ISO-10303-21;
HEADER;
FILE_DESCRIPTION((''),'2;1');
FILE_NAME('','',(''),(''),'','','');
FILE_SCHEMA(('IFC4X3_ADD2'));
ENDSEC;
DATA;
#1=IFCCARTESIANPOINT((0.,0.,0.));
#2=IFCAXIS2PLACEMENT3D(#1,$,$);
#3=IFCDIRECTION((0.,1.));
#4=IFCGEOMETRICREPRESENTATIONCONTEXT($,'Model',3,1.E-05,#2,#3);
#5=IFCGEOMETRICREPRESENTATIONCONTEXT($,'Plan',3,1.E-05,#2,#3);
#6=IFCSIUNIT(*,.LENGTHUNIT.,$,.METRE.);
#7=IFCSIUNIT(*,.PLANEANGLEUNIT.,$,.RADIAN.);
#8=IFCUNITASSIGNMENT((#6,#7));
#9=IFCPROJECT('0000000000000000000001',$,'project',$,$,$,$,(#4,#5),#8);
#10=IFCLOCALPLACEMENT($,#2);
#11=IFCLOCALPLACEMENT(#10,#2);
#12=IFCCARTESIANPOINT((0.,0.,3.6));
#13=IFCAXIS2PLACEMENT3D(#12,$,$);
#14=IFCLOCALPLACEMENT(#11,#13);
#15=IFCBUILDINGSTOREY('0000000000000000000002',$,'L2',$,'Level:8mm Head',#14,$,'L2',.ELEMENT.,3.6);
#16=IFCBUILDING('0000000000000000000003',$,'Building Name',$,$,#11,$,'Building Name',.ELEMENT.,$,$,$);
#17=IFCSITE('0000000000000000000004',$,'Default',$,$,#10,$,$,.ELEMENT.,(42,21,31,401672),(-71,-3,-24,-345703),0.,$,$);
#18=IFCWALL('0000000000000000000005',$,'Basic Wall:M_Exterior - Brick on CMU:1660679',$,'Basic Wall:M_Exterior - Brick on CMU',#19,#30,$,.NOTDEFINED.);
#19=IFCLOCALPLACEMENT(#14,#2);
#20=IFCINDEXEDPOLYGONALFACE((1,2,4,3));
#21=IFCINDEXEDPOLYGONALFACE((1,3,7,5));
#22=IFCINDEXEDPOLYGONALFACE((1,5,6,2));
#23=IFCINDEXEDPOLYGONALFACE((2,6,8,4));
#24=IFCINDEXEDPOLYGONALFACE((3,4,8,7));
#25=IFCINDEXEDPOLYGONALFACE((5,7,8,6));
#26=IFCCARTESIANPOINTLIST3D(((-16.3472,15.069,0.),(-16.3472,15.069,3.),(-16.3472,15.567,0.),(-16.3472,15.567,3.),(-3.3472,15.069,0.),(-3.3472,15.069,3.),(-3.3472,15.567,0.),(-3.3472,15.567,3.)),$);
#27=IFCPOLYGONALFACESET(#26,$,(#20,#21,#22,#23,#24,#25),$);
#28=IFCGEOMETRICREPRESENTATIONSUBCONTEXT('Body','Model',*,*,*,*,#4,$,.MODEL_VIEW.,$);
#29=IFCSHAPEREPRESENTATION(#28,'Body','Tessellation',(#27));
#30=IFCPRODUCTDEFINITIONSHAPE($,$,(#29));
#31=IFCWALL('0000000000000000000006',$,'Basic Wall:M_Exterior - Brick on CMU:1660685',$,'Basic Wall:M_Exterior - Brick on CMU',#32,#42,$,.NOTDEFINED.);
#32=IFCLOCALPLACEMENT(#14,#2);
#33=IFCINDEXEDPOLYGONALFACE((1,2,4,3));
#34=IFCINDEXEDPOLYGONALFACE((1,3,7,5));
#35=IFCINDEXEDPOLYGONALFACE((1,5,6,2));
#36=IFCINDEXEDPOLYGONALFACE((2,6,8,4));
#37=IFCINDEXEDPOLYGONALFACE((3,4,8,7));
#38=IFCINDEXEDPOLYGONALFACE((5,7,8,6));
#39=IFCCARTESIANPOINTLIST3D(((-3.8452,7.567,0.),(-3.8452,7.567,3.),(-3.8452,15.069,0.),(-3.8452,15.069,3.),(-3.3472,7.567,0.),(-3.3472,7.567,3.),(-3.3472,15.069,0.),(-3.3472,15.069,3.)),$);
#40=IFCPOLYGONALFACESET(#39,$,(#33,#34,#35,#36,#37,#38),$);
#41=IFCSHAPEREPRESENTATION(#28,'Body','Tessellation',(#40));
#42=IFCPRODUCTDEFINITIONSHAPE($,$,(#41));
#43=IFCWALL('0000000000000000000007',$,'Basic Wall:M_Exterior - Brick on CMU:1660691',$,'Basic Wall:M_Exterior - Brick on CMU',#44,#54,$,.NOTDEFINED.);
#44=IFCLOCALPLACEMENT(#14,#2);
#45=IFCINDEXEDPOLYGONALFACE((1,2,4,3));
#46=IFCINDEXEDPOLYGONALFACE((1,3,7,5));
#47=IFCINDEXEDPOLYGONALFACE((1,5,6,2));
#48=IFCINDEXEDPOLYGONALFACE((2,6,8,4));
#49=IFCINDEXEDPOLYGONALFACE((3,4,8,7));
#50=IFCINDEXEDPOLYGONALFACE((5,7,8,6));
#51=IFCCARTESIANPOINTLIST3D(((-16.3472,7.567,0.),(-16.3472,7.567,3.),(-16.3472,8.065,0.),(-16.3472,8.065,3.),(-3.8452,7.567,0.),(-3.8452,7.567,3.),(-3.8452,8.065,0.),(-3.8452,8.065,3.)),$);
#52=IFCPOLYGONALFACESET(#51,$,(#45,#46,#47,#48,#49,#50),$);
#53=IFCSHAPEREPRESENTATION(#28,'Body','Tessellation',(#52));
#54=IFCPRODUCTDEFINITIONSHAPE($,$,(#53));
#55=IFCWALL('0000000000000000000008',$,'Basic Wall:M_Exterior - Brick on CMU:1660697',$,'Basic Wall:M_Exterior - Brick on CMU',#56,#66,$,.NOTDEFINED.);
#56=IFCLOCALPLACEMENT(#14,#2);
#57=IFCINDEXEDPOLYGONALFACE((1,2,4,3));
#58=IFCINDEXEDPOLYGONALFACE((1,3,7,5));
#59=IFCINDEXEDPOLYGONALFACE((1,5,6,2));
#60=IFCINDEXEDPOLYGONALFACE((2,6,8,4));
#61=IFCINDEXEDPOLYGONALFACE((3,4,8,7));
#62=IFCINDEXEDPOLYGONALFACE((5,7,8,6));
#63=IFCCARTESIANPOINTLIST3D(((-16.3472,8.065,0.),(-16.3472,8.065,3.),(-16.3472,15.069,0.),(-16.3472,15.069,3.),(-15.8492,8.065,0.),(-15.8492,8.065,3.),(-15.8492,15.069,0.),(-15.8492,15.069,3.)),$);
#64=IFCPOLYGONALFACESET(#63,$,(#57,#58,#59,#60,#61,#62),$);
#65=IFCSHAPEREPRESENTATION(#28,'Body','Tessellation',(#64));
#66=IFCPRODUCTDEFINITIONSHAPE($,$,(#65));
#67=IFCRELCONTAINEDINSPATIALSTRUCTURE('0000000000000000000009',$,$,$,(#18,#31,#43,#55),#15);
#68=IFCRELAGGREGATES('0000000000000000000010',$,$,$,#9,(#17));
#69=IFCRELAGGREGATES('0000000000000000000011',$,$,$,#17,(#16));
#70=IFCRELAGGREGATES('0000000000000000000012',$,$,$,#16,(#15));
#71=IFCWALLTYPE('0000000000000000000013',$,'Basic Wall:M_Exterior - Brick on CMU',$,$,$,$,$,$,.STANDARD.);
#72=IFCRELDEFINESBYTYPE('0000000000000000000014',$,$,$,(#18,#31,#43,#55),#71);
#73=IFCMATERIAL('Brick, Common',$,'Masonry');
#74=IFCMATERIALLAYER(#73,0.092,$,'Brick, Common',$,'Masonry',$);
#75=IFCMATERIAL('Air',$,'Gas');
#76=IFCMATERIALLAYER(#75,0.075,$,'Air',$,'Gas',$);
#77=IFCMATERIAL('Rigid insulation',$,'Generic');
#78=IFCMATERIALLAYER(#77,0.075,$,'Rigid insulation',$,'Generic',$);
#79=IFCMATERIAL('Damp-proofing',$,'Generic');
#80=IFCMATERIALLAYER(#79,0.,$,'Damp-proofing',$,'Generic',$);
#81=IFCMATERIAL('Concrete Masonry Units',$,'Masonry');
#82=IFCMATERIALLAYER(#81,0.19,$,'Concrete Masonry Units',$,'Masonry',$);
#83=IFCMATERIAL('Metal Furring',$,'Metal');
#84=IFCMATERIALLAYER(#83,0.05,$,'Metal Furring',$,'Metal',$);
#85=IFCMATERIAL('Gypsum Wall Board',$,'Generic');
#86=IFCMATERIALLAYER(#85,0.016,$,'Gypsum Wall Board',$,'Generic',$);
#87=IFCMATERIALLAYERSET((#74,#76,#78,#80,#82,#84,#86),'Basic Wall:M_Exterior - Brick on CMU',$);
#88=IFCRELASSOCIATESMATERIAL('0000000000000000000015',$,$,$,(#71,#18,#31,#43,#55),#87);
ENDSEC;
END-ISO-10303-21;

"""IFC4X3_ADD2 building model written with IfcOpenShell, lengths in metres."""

from ifc_helpers import new_model, si_unit, direction, frame, frame_2d, origin, place, context, subcontext, project, spatial, rectangle, extrude, material, layer, layer_set, type_object, element, save


model = new_model("IFC4X3_ADD2")

# Units and contexts
model_context = context("Model", 3, precision=1e-05, world=origin(), true_north=direction((0.0, 1.0)))
plan_context = context("Plan", 3, precision=1e-05, world=origin(), true_north=direction((0.0, 1.0)))
body_context = subcontext(model_context, "Body", "Model", "MODEL_VIEW")
ifc_project = project(units=[si_unit("LENGTHUNIT", "METRE"), si_unit("PLANEANGLEUNIT", "RADIAN")], contexts=[model_context, plan_context])

# Site, building, storey
site_placement = place(None, origin())
site = spatial("IfcSite", under=ifc_project, at=site_placement, Name="Default", CompositionType="ELEMENT", RefLatitude=(42, 21, 31, 401672), RefLongitude=(-71, -3, -24, -345703), RefElevation=0.0)
building_placement = place(site_placement, origin())
building = spatial("IfcBuilding", under=site, at=building_placement, Name="Building Name", LongName="Building Name", CompositionType="ELEMENT")
storey_placement = place(building_placement, frame((0.0, 0.0, 3.6)))
storey = spatial("IfcBuildingStorey", under=building, at=storey_placement, Name="L2", ObjectType="Level:8mm Head", LongName="L2", CompositionType="ELEMENT", Elevation=3.6)

# Walls
ifc_material_1 = material(Name="Brick, Common", Category="Masonry")
ifc_layer_1 = layer(ifc_material_1, 0.092, Name="Brick, Common", Category="Masonry")
ifc_material_2 = material(Name="Air", Category="Gas")
ifc_layer_2 = layer(ifc_material_2, 0.075, Name="Air", Category="Gas")
ifc_material_3 = material(Name="Rigid insulation", Category="Generic")
ifc_layer_3 = layer(ifc_material_3, 0.075, Name="Rigid insulation", Category="Generic")
ifc_material_4 = material(Name="Damp-proofing", Category="Generic")
ifc_layer_4 = layer(ifc_material_4, 0.0, Name="Damp-proofing", Category="Generic")
ifc_material_5 = material(Name="Concrete Masonry Units", Category="Masonry")
ifc_layer_5 = layer(ifc_material_5, 0.19, Name="Concrete Masonry Units", Category="Masonry")
ifc_material_6 = material(Name="Metal Furring", Category="Metal")
ifc_layer_6 = layer(ifc_material_6, 0.05, Name="Metal Furring", Category="Metal")
ifc_material_7 = material(Name="Gypsum Wall Board", Category="Generic")
ifc_layer_7 = layer(ifc_material_7, 0.016, Name="Gypsum Wall Board", Category="Generic")
ifc_layer_set = layer_set([ifc_layer_1, ifc_layer_2, ifc_layer_3, ifc_layer_4, ifc_layer_5, ifc_layer_6, ifc_layer_7], Name="Basic Wall:M_Exterior - Brick on CMU")
wall_type = type_object("IfcWallType", Name="Basic Wall:M_Exterior - Brick on CMU", PredefinedType="STANDARD", material=ifc_layer_set)
wall_1_placement = place(storey_placement, frame((-16.3472, 15.318, 0.0)))
element("IfcWall", 1, at=wall_1_placement, inside=storey, type_object=wall_type, material=ifc_layer_set, Name="Basic Wall:M_Exterior - Brick on CMU:1660679", ObjectType="Basic Wall:M_Exterior - Brick on CMU", PredefinedType="NOTDEFINED", context=body_context, shape_type="SweptSolid", body=[
    extrude(rectangle(XDim=13.0, YDim=0.498, at=frame_2d((6.5, 0.0), x_axis=(-1.0, 0.0))), origin(), (0.0, 0.0, 1.0), 3.0),
])
wall_2_placement = place(storey_placement, frame((-3.5962, 15.069, 0.0), z_axis=(0.0, 0.0, 1.0), x_axis=(0.0, -1.0, 0.0)))
element("IfcWall", 2, at=wall_2_placement, inside=storey, type_object=wall_type, material=ifc_layer_set, Name="Basic Wall:M_Exterior - Brick on CMU:1660685", ObjectType="Basic Wall:M_Exterior - Brick on CMU", PredefinedType="NOTDEFINED", context=body_context, shape_type="SweptSolid", body=[
    extrude(rectangle(XDim=7.502, YDim=0.498, at=frame_2d((3.751, 0.0), x_axis=(-1.0, 0.0))), origin(), (0.0, 0.0, 1.0), 3.0),
])
wall_3_placement = place(storey_placement, frame((-3.8452, 7.816, 0.0), z_axis=(0.0, 0.0, 1.0), x_axis=(-1.0, 0.0, 0.0)))
element("IfcWall", 3, at=wall_3_placement, inside=storey, type_object=wall_type, material=ifc_layer_set, Name="Basic Wall:M_Exterior - Brick on CMU:1660691", ObjectType="Basic Wall:M_Exterior - Brick on CMU", PredefinedType="NOTDEFINED", context=body_context, shape_type="SweptSolid", body=[
    extrude(rectangle(XDim=12.502, YDim=0.498, at=frame_2d((6.251, 0.0), x_axis=(-1.0, 0.0))), origin(), (0.0, 0.0, 1.0), 3.0),
])
wall_4_placement = place(storey_placement, frame((-16.0982, 8.065, 0.0), z_axis=(0.0, 0.0, 1.0), x_axis=(0.0, 1.0, 0.0)))
element("IfcWall", 4, at=wall_4_placement, inside=storey, type_object=wall_type, material=ifc_layer_set, Name="Basic Wall:M_Exterior - Brick on CMU:1660697", ObjectType="Basic Wall:M_Exterior - Brick on CMU", PredefinedType="NOTDEFINED", context=body_context, shape_type="SweptSolid", body=[
    extrude(rectangle(XDim=7.004, YDim=0.498, at=frame_2d((3.502, 0.0), x_axis=(-1.0, 0.0))), origin(), (0.0, 0.0, 1.0), 3.0),
])

save(model, "model.ifc")
